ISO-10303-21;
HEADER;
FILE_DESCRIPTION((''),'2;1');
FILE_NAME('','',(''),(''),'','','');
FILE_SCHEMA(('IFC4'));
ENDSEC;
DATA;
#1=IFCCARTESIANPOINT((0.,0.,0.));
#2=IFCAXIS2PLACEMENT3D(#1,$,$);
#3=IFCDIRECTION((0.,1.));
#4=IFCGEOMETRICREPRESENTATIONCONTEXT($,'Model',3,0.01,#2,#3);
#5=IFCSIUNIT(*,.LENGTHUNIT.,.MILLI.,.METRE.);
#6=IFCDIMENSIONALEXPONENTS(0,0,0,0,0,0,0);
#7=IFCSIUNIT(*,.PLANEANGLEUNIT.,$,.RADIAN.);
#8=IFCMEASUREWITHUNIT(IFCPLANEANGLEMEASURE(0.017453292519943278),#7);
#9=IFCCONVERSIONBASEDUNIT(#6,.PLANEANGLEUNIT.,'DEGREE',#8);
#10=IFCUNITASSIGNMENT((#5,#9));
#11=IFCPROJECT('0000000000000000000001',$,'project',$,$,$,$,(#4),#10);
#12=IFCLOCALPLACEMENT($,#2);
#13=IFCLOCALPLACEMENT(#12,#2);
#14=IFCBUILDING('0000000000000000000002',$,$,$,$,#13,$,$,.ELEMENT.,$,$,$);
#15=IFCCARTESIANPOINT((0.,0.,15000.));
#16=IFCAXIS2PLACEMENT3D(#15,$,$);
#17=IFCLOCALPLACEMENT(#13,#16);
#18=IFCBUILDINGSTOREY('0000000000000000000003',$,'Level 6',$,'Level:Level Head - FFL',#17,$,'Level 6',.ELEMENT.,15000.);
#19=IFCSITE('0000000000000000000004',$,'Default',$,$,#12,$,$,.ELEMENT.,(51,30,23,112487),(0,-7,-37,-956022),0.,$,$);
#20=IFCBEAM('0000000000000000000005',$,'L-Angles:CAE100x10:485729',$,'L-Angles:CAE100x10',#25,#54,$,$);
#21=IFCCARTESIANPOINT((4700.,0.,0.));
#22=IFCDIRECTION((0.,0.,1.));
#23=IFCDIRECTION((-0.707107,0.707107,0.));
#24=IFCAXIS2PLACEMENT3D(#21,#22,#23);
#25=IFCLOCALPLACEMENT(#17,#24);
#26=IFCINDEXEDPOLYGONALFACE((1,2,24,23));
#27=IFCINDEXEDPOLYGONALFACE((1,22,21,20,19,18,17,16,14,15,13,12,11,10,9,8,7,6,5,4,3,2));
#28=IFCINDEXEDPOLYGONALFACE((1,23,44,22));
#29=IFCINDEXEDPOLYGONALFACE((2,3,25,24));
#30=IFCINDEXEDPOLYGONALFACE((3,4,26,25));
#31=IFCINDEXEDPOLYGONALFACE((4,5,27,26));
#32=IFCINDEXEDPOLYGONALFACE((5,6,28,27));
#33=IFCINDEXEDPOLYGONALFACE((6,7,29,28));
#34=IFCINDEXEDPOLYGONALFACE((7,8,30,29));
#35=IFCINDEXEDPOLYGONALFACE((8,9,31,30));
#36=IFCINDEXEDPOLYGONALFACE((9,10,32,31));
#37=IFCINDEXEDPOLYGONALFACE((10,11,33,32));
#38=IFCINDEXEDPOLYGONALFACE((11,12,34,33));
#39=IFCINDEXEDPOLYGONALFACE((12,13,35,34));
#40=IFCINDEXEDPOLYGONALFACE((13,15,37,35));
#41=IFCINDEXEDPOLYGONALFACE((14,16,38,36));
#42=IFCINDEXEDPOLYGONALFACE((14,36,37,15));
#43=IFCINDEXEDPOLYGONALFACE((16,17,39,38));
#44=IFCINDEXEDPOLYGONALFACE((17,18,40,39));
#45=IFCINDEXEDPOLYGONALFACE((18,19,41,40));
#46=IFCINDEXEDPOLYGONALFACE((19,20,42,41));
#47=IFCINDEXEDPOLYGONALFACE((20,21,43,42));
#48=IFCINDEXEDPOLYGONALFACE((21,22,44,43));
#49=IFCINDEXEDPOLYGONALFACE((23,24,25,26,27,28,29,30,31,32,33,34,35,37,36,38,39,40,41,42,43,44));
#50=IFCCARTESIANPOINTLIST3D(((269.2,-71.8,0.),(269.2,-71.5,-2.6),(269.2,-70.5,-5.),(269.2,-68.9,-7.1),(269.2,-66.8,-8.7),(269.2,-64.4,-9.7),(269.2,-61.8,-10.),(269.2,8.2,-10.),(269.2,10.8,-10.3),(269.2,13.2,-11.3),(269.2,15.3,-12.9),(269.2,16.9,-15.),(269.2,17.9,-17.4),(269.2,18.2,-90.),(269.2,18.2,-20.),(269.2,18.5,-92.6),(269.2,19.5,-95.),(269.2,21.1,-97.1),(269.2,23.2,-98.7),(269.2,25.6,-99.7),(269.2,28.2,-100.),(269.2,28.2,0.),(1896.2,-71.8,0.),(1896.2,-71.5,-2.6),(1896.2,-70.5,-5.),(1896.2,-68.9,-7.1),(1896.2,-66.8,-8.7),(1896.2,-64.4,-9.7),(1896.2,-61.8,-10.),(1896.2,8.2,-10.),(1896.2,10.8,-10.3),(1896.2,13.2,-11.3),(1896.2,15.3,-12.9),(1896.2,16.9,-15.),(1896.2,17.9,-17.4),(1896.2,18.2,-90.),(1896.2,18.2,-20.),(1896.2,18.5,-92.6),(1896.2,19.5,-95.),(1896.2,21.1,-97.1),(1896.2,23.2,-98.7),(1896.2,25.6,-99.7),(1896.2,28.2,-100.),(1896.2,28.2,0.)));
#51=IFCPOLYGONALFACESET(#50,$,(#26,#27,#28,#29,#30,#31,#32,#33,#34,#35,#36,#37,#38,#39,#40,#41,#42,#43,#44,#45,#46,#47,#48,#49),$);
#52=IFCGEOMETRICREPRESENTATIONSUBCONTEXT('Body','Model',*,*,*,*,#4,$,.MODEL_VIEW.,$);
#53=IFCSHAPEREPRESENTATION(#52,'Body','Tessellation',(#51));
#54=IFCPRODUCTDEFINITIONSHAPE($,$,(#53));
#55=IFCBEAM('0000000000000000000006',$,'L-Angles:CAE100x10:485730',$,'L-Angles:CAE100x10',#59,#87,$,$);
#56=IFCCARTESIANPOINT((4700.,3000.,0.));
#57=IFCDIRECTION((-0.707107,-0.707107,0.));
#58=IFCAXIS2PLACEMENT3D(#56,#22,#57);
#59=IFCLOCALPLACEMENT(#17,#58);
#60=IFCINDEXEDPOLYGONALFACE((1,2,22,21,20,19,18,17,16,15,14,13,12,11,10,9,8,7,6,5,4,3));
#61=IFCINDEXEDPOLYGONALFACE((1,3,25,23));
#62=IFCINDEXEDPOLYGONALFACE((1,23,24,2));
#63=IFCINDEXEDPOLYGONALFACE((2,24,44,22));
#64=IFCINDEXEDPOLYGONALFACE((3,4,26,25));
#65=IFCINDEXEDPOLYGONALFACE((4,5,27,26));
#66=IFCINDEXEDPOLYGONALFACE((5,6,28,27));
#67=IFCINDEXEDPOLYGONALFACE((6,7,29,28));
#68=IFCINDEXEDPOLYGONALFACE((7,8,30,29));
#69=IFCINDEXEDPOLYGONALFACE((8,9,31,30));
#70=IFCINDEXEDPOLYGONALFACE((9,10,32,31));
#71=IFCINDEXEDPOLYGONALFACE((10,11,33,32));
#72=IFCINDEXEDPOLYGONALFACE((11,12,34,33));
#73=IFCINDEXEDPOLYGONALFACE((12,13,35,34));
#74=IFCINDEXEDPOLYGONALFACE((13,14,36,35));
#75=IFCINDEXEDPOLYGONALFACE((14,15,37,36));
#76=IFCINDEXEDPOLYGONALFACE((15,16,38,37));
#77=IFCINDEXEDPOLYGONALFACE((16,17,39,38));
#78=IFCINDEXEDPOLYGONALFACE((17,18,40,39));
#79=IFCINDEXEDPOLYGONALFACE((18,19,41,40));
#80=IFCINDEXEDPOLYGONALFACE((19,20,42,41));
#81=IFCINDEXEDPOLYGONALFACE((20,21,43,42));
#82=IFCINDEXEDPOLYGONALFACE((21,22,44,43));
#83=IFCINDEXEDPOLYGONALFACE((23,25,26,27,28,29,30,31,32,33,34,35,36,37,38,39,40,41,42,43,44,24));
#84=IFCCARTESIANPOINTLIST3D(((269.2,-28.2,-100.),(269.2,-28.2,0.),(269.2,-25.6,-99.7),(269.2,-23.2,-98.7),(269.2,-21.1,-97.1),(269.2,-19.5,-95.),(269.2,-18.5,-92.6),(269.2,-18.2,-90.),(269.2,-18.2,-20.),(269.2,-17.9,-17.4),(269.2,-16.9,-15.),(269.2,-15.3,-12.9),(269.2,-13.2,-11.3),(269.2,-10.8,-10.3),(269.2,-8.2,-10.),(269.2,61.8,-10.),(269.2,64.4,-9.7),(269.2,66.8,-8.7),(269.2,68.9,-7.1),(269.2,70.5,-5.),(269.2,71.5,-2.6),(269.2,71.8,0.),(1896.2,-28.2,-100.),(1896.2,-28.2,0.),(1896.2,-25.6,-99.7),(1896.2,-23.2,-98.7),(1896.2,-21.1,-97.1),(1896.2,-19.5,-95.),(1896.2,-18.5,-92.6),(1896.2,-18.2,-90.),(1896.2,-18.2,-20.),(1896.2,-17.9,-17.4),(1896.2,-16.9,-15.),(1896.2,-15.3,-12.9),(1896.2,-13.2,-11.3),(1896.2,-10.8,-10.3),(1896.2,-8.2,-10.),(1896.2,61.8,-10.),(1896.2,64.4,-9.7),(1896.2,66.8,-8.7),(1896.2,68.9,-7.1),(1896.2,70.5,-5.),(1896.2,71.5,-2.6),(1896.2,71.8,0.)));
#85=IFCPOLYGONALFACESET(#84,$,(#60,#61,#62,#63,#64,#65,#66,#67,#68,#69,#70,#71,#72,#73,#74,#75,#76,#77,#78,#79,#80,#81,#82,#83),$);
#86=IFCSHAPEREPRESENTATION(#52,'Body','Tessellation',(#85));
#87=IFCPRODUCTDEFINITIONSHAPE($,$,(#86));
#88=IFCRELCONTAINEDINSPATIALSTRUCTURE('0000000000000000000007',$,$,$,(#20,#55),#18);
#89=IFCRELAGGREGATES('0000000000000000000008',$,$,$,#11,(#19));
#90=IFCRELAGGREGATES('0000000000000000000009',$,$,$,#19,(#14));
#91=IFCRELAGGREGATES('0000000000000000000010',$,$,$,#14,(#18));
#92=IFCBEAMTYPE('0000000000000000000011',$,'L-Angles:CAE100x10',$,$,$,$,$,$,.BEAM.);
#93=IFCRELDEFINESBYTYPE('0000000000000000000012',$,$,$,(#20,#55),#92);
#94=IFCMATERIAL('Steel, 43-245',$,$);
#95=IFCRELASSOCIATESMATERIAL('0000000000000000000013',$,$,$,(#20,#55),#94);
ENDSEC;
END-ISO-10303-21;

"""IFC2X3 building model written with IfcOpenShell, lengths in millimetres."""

from ifc_helpers import new_model, entity, si_unit, converted_unit, direction, frame, frame_2d, origin, place, context, subcontext, project, spatial, polyline, circle_curve, parameter, trimmed, segment, composite_curve, outline, extrude, material, type_object, element, save


model = new_model("IFC2X3")

# Units and contexts
model_context = context("Model", 3, precision=0.01, world=origin(), true_north=direction((0.0, 1.0)))
body_context = subcontext(model_context, "Body", "Model", "MODEL_VIEW")
ifc_project = project(units=[si_unit("LENGTHUNIT", "METRE", prefix="MILLI"), converted_unit("PLANEANGLEUNIT", "DEGREE", entity("IfcPlaneAngleMeasure", 0.017453292519943278), si_unit("PLANEANGLEUNIT", "RADIAN"), dimensions=[0, 0, 0, 0, 0, 0, 0])], contexts=[model_context])

# Site, building, storey
site_placement = place(None, origin())
site = spatial("IfcSite", under=ifc_project, at=site_placement, Name="Default", CompositionType="ELEMENT", RefLatitude=(51, 30, 23, 112487), RefLongitude=(0, -7, -37, -956022), RefElevation=0.0)
building_placement = place(site_placement, origin())
building = spatial("IfcBuilding", under=site, at=building_placement, CompositionType="ELEMENT")
storey_placement = place(building_placement, frame((0.0, 0.0, 15000.0)))
storey = spatial("IfcBuildingStorey", under=building, at=storey_placement, Name="Level 6", ObjectType="Level:Level Head - FFL", LongName="Level 6", CompositionType="ELEMENT", Elevation=15000.0)

# Beams
ifc_material = material(Name="Steel, 43-245")
beam_type_1 = type_object("IfcBeamType", Name="L-Angles:CAE100x10", PredefinedType="BEAM")
beam_1_placement = place(storey_placement, frame((4700.0, 0.0, 0.0), z_axis=(0.0, 0.0, 1.0), x_axis=(-0.707107, 0.707107, 0.0)))
element("IfcBeam", 1, at=beam_1_placement, inside=storey, type_object=beam_type_1, material=ifc_material, Name="L-Angles:CAE100x10:485729", ObjectType="L-Angles:CAE100x10", context=body_context, shape_type="SweptSolid", body=[
    extrude(outline(composite_curve([segment(polyline([(-67.1, -32.9), (32.9, -32.9)]), True, "CONTINUOUS"), segment(polyline([(32.9, -32.9), (32.9, 67.1)]), True, "CONTINUOUS"), segment(trimmed(circle_curve(frame_2d((32.9, 57.1), x_axis=(0.0, 1.0)), 10.0), [parameter(0.0)], [parameter(90.0)], True, "PARAMETER"), True, "CONTINUOUS"), segment(polyline([(22.9, 57.1), (22.9, -12.9)]), True, "CONTINUOUS"), segment(trimmed(circle_curve(frame_2d((12.9, -12.9), x_axis=(1.0, 0.0)), 10.0), [parameter(270.0)], [parameter(0.0)], True, "PARAMETER"), False, "CONTINUOUS"), segment(polyline([(12.9, -22.9), (-57.1, -22.9)]), True, "CONTINUOUS"), segment(trimmed(circle_curve(frame_2d((-57.1, -32.9), x_axis=(0.0, 1.0)), 10.0), [parameter(0.0)], [parameter(90.0)], True, "PARAMETER"), True, "CONTINUOUS")], self_intersect=False)), frame((269.2, -4.7, -32.9), z_axis=(1.0, 0.0, 0.0), x_axis=(0.0, 0.0, 1.0)), (0.0, 0.0, 1.0), 1627.0),
])
beam_2_placement = place(storey_placement, frame((4700.0, 3000.0, 0.0), z_axis=(0.0, 0.0, 1.0), x_axis=(-0.707107, -0.707107, 0.0)))
element("IfcBeam", 2, at=beam_2_placement, inside=storey, type_object=beam_type_1, material=ifc_material, Name="L-Angles:CAE100x10:485730", ObjectType="L-Angles:CAE100x10", context=body_context, shape_type="SweptSolid", body=[
    extrude(outline(composite_curve([segment(polyline([(-32.9, -32.9), (67.1, -32.9)]), True, "CONTINUOUS"), segment(trimmed(circle_curve(frame_2d((57.1, -32.9), x_axis=(1.0, 0.0)), 10.0), [parameter(0.0)], [parameter(90.0)], True, "PARAMETER"), True, "CONTINUOUS"), segment(polyline([(57.1, -22.9), (-12.9, -22.9)]), True, "CONTINUOUS"), segment(trimmed(circle_curve(frame_2d((-12.9, -12.9), x_axis=(0.0, -1.0)), 10.0), [parameter(270.0)], [parameter(0.0)], True, "PARAMETER"), False, "CONTINUOUS"), segment(polyline([(-22.9, -12.9), (-22.9, 57.1)]), True, "CONTINUOUS"), segment(trimmed(circle_curve(frame_2d((-32.9, 57.1), x_axis=(1.0, 0.0)), 10.0), [parameter(0.0)], [parameter(90.0)], True, "PARAMETER"), True, "CONTINUOUS"), segment(polyline([(-32.9, 67.1), (-32.9, -32.9)]), True, "CONTINUOUS")], self_intersect=False)), frame((269.2, 4.7, -32.9), z_axis=(1.0, 0.0, 0.0), x_axis=(0.0, 0.0, -1.0)), (0.0, 0.0, 1.0), 1627.0),
])

save(model, "model.ifc")
